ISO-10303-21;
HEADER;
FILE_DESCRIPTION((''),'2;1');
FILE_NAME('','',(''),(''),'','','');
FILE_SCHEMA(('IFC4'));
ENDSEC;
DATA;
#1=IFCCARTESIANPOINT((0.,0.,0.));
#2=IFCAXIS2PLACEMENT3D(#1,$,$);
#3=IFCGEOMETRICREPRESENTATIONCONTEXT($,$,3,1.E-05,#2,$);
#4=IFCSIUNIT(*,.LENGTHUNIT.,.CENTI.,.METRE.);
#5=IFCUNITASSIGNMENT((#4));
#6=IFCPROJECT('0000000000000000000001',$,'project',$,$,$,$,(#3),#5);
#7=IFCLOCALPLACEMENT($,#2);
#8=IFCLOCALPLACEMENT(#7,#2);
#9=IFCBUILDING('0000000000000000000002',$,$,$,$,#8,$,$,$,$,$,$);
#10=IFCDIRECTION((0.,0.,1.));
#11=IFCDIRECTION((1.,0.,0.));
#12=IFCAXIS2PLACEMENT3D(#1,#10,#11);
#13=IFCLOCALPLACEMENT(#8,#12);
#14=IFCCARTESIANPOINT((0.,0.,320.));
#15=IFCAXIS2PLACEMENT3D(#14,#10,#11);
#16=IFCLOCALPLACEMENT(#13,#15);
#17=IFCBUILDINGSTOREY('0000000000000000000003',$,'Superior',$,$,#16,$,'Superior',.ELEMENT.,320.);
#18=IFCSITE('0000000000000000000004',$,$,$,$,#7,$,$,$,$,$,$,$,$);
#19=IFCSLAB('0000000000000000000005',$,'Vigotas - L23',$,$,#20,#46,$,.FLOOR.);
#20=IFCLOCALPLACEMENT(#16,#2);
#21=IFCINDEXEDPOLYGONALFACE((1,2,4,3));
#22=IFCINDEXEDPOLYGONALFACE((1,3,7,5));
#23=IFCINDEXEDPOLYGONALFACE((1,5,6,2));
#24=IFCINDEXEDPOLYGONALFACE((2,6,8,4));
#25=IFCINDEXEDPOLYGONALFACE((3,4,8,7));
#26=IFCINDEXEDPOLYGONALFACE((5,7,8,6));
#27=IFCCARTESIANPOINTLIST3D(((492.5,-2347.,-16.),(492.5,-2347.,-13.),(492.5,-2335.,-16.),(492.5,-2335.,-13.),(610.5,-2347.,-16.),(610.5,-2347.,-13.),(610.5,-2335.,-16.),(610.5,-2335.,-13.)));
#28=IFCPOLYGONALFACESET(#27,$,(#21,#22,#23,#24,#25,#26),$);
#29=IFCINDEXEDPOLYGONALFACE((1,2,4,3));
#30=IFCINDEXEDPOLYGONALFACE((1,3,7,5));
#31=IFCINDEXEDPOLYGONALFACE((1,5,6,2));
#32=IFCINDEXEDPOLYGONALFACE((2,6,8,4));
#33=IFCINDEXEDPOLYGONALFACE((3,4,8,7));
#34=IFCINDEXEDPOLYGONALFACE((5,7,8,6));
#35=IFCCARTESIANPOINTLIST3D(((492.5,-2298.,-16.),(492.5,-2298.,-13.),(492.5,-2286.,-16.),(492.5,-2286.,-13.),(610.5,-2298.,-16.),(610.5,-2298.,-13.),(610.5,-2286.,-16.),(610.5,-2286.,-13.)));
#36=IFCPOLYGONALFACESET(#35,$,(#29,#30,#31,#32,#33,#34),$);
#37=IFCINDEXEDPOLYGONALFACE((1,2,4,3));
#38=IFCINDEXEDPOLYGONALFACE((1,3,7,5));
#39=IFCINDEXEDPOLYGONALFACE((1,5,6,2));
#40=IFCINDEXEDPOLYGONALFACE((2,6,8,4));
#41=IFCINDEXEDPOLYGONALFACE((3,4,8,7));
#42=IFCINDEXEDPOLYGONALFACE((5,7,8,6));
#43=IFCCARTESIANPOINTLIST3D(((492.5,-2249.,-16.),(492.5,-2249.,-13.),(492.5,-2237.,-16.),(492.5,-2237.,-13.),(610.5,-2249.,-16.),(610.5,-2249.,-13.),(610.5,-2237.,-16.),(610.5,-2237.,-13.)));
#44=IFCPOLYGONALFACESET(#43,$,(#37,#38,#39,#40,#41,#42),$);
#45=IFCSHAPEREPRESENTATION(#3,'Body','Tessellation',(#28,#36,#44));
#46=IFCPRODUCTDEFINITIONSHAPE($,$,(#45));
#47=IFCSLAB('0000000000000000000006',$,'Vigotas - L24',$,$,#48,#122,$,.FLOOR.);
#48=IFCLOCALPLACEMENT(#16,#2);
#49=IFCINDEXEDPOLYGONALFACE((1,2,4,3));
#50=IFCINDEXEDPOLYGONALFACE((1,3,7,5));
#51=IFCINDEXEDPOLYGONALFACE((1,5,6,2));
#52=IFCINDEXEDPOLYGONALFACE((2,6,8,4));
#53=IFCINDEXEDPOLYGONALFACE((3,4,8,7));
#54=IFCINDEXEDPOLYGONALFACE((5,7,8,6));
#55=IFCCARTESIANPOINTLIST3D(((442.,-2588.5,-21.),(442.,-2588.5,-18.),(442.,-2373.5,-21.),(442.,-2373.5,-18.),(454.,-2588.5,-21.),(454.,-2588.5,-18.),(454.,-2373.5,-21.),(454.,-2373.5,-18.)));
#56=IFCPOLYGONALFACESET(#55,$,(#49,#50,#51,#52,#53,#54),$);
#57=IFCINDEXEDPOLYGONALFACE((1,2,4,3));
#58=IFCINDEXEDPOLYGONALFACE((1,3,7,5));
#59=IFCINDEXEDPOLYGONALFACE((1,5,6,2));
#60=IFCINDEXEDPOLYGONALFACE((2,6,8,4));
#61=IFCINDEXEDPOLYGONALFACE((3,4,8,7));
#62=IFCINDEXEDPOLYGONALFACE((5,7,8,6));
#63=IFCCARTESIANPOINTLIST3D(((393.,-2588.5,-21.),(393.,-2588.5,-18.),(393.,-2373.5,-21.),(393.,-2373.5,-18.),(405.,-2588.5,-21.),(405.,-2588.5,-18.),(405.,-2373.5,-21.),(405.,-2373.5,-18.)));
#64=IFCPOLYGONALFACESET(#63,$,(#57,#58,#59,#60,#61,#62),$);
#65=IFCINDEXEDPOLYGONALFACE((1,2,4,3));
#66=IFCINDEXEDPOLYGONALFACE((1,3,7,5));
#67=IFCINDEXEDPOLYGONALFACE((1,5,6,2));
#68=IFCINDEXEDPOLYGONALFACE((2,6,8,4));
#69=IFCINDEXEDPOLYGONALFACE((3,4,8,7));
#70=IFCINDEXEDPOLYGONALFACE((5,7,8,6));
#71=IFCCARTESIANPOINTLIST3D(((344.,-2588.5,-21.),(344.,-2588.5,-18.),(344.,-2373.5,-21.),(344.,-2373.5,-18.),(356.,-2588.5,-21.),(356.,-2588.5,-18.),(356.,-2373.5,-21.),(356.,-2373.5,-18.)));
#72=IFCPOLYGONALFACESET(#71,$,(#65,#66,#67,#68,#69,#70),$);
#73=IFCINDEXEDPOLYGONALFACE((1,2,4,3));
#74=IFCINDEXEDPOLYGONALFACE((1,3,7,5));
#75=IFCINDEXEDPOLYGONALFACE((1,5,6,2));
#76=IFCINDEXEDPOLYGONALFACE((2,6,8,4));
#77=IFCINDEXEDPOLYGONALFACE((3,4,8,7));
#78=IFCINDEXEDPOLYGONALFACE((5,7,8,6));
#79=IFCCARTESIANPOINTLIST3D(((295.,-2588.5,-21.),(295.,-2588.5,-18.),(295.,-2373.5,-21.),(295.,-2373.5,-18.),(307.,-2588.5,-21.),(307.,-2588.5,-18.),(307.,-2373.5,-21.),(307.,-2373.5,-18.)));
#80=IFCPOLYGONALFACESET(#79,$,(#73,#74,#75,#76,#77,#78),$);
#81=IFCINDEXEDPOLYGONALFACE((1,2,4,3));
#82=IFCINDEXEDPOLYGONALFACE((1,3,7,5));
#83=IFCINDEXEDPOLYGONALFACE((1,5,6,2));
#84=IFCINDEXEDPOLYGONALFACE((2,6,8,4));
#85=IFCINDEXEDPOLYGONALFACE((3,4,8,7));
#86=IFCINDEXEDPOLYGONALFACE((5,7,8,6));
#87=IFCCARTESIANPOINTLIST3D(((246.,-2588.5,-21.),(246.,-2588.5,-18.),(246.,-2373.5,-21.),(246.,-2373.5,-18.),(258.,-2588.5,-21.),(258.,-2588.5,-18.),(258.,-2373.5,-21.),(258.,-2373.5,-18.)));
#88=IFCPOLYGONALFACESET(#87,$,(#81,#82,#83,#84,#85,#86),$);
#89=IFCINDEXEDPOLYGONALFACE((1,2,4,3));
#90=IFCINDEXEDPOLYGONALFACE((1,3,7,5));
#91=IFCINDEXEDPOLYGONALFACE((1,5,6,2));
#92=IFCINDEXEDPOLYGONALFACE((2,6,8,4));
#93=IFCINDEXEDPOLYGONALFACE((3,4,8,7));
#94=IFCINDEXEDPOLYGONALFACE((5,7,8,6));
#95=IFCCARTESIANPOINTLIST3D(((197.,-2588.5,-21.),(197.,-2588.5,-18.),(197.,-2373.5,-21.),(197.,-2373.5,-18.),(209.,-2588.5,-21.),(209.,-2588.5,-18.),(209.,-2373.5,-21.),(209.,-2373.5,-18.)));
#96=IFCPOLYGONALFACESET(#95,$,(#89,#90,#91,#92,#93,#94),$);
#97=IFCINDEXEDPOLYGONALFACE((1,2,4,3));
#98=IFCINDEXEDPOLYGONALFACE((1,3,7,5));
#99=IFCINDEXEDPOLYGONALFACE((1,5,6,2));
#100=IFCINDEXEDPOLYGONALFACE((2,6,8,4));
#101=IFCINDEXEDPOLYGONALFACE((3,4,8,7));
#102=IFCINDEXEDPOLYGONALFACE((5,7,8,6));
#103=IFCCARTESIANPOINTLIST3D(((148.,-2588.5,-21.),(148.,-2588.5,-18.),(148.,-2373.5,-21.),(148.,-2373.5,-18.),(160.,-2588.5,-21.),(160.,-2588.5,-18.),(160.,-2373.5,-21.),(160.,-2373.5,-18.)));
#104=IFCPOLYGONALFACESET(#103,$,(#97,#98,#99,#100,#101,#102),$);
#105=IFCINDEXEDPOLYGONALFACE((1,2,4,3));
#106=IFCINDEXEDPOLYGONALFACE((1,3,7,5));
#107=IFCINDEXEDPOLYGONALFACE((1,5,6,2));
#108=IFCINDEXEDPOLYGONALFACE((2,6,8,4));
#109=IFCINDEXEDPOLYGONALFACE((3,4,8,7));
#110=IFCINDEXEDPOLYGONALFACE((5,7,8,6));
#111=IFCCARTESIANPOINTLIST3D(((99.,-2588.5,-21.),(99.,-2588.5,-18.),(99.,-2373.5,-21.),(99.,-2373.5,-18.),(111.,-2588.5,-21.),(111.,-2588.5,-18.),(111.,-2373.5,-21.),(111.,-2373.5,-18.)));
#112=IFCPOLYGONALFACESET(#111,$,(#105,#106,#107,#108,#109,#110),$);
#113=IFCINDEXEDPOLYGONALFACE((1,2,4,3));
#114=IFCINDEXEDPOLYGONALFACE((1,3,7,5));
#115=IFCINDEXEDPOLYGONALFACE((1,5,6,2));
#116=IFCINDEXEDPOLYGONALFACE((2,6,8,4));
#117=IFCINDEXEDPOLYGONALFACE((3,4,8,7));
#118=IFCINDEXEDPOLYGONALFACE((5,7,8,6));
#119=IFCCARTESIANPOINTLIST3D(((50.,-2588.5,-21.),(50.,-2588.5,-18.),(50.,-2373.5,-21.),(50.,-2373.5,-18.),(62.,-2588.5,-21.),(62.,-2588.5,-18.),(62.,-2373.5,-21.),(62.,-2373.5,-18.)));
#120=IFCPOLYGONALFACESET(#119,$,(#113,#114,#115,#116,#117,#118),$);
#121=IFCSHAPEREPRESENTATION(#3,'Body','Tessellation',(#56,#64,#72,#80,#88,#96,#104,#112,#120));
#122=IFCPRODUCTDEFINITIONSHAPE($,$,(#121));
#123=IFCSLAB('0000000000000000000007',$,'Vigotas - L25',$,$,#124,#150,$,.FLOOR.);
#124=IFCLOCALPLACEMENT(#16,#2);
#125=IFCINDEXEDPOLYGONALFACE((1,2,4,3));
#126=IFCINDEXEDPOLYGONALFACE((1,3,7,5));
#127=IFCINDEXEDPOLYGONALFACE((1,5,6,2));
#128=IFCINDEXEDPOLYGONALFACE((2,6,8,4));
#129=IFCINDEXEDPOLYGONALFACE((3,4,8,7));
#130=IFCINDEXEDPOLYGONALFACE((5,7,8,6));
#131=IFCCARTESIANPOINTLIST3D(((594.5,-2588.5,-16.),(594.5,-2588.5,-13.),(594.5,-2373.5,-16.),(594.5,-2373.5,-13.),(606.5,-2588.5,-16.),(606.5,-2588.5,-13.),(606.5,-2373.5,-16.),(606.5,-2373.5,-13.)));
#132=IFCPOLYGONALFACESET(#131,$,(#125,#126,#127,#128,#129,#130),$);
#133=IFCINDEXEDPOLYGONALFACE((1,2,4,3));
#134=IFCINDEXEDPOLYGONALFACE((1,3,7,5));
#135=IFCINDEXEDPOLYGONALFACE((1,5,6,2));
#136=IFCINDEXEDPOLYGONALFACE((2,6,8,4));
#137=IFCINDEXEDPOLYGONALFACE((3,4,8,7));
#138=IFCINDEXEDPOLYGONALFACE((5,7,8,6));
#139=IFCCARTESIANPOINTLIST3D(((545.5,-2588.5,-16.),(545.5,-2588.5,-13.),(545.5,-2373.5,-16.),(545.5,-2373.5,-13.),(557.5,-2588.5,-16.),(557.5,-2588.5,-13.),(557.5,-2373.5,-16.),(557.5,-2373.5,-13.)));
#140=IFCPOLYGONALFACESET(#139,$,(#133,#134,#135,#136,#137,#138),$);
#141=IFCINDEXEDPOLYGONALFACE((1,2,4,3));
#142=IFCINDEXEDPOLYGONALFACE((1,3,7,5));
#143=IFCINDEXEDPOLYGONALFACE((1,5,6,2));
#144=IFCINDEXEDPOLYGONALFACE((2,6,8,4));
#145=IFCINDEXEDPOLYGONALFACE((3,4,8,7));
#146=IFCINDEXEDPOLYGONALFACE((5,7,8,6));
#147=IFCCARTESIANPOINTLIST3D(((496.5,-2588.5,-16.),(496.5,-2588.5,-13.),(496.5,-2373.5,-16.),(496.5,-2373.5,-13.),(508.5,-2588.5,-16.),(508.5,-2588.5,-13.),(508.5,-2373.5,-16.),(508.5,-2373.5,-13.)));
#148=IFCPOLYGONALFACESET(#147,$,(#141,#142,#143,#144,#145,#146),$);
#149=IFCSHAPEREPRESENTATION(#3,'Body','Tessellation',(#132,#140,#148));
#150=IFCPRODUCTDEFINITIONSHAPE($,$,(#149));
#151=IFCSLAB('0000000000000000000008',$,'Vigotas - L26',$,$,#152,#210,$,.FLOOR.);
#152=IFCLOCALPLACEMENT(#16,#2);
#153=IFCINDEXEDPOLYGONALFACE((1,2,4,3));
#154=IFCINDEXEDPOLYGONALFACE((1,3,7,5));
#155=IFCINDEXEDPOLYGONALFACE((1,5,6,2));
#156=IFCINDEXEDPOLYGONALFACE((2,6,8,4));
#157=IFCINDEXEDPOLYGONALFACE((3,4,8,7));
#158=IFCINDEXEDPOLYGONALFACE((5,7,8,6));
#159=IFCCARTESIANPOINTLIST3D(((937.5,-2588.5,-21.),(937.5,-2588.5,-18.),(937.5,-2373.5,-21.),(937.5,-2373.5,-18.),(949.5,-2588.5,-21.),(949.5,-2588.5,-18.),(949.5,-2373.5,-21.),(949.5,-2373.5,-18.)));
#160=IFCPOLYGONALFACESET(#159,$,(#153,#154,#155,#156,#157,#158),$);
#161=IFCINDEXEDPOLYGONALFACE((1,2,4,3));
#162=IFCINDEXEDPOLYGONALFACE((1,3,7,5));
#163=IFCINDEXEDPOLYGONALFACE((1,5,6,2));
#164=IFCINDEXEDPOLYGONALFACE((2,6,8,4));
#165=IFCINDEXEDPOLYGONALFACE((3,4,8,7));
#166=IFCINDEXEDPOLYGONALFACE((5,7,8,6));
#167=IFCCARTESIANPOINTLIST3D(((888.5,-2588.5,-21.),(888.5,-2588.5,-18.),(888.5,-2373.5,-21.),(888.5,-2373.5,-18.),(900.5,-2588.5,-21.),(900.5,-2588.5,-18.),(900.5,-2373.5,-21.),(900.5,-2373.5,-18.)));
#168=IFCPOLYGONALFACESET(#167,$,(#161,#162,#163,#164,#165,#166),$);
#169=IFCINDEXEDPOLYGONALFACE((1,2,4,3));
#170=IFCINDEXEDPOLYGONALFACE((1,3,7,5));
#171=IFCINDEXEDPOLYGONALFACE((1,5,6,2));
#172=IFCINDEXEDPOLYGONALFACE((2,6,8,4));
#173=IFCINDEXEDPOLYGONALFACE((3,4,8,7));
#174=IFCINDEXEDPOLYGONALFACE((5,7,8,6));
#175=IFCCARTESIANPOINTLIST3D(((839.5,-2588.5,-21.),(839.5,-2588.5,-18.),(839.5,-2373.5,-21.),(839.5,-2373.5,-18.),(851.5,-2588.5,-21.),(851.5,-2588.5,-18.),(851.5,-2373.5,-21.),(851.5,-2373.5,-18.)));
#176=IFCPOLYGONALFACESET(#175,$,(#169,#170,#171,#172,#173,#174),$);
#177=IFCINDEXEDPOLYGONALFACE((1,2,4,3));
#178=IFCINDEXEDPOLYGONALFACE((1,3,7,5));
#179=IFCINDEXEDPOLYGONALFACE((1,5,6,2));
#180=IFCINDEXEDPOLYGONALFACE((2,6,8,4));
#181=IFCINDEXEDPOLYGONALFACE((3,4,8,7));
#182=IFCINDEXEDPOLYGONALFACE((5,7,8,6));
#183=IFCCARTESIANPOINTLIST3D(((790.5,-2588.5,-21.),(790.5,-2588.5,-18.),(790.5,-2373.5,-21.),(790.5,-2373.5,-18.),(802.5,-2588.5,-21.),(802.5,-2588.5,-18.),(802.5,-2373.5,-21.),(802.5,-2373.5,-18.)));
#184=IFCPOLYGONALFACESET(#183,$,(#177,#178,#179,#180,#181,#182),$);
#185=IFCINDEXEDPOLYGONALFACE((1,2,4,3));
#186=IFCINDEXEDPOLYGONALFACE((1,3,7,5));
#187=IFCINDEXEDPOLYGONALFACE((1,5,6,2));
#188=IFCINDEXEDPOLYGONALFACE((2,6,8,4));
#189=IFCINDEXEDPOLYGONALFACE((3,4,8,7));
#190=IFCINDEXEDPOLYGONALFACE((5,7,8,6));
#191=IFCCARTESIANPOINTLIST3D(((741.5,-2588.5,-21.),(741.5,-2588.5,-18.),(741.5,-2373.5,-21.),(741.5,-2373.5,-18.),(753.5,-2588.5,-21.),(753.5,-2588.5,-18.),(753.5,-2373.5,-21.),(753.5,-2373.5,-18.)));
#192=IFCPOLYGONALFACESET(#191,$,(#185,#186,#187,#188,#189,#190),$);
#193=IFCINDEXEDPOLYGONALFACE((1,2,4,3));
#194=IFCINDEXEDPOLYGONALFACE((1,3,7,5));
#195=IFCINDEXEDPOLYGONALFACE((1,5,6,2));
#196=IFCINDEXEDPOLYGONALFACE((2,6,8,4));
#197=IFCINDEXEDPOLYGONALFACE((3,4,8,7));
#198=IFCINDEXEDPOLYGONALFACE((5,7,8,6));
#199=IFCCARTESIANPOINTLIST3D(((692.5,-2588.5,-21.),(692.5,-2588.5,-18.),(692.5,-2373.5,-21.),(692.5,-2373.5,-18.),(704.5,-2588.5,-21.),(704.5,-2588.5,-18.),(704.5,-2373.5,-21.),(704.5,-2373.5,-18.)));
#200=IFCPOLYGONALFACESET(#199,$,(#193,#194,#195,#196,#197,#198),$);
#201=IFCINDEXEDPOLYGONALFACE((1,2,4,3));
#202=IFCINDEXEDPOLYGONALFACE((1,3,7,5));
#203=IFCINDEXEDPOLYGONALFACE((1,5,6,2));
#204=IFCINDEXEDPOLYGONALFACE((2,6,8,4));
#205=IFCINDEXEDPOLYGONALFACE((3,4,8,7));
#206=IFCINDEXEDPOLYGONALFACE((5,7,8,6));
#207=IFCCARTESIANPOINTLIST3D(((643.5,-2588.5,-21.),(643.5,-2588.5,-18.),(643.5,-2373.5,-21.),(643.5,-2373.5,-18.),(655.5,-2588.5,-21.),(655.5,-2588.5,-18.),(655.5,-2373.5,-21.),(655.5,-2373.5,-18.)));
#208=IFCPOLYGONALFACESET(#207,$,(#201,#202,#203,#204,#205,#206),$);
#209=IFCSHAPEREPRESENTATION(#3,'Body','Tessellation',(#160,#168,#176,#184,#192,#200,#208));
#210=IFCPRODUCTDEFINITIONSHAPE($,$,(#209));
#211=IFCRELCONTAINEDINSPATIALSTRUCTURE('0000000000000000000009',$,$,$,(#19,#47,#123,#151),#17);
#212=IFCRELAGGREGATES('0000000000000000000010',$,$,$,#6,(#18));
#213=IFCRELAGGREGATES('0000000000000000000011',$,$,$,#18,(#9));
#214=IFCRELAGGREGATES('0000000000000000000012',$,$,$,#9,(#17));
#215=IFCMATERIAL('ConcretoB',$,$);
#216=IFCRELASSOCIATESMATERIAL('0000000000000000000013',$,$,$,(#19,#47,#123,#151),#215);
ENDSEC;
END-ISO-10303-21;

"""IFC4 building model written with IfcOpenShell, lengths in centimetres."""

from ifc_helpers import new_model, si_unit, frame, origin, origin_with_axes, place, context, project, spatial, polyline, outline, extrude, material, element, save


model = new_model("IFC4")

# Units and contexts
context_of_model = context(None, 3, precision=1e-05, world=origin())
ifc_project = project(units=[si_unit("LENGTHUNIT", "METRE", prefix="CENTI")], contexts=[context_of_model])

# Site, building, storey
site_placement = place(None, origin())
site = spatial("IfcSite", under=ifc_project, at=site_placement)
building_placement = place(site_placement, origin())
building = spatial("IfcBuilding", under=site, at=building_placement)
placement = place(building_placement, origin_with_axes())
storey_placement = place(placement, frame((0.0, 0.0, 320.0), z_axis=(0.0, 0.0, 1.0), x_axis=(1.0, 0.0, 0.0)))
storey = spatial("IfcBuildingStorey", under=building, at=storey_placement, Name="Superior", LongName="Superior", CompositionType="ELEMENT", Elevation=320.0)

# Shared definitions
ifc_material = material(Name="ConcretoB")

# Slabs
slab_1_placement = place(storey_placement, frame((551.5, -2292.0, -13.0), z_axis=(0.0, 0.0, 1.0), x_axis=(1.0, 0.0, 0.0)))
element("IfcSlab", 1, at=slab_1_placement, inside=storey, material=ifc_material, Name="Vigotas - L23", PredefinedType="FLOOR", context=context_of_model, shape_type="SolidModel", body=[
    extrude(outline(polyline([(6.0, 1.5), (-6.0, 1.5), (-6.0, -1.5), (6.0, -1.5), (6.0, 1.5), (6.0, 1.5)])), frame((-59.0, -49.0, -1.5), z_axis=(1.0, 0.0, 0.0), x_axis=(0.0, -1.0, 0.0)), (0.0, 0.0, 1.0), 118.0),
    extrude(outline(polyline([(6.0, 1.5), (-6.0, 1.5), (-6.0, -1.5), (6.0, -1.5), (6.0, 1.5), (6.0, 1.5)])), frame((-59.0, 0.0, -1.5), z_axis=(1.0, 0.0, 0.0), x_axis=(0.0, -1.0, 0.0)), (0.0, 0.0, 1.0), 118.0),
    extrude(outline(polyline([(6.0, 1.5), (-6.0, 1.5), (-6.0, -1.5), (6.0, -1.5), (6.0, 1.5), (6.0, 1.5)])), frame((-59.0, 49.0, -1.5), z_axis=(1.0, 0.0, 0.0), x_axis=(0.0, -1.0, 0.0)), (0.0, 0.0, 1.0), 118.0),
])
slab_2_placement = place(storey_placement, frame((252.0, -2481.0, -18.0), z_axis=(0.0, 0.0, 1.0), x_axis=(1.0, 0.0, 0.0)))
element("IfcSlab", 2, at=slab_2_placement, inside=storey, material=ifc_material, Name="Vigotas - L24", PredefinedType="FLOOR", context=context_of_model, shape_type="SolidModel", body=[
    extrude(outline(polyline([(6.0, 1.5), (-6.0, 1.5), (-6.0, -1.5), (6.0, -1.5), (6.0, 1.5), (6.0, 1.5)])), frame((196.0, -107.5, -1.5), z_axis=(0.0, 1.0, 0.0), x_axis=(1.0, 0.0, 0.0)), (0.0, 0.0, 1.0), 215.0),
    extrude(outline(polyline([(6.0, 1.5), (-6.0, 1.5), (-6.0, -1.5), (6.0, -1.5), (6.0, 1.5), (6.0, 1.5)])), frame((147.0, -107.5, -1.5), z_axis=(0.0, 1.0, 0.0), x_axis=(1.0, 0.0, 0.0)), (0.0, 0.0, 1.0), 215.0),
    extrude(outline(polyline([(6.0, 1.5), (-6.0, 1.5), (-6.0, -1.5), (6.0, -1.5), (6.0, 1.5), (6.0, 1.5)])), frame((98.0, -107.5, -1.5), z_axis=(0.0, 1.0, 0.0), x_axis=(1.0, 0.0, 0.0)), (0.0, 0.0, 1.0), 215.0),
    extrude(outline(polyline([(6.0, 1.5), (-6.0, 1.5), (-6.0, -1.5), (6.0, -1.5), (6.0, 1.5), (6.0, 1.5)])), frame((49.0, -107.5, -1.5), z_axis=(0.0, 1.0, 0.0), x_axis=(1.0, 0.0, 0.0)), (0.0, 0.0, 1.0), 215.0),
    extrude(outline(polyline([(6.0, 1.5), (-6.0, 1.5), (-6.0, -1.5), (6.0, -1.5), (6.0, 1.5), (6.0, 1.5)])), frame((0.0, -107.5, -1.5), z_axis=(0.0, 1.0, 0.0), x_axis=(1.0, 0.0, 0.0)), (0.0, 0.0, 1.0), 215.0),
    extrude(outline(polyline([(6.0, 1.5), (-6.0, 1.5), (-6.0, -1.5), (6.0, -1.5), (6.0, 1.5), (6.0, 1.5)])), frame((-49.0, -107.5, -1.5), z_axis=(0.0, 1.0, 0.0), x_axis=(1.0, 0.0, 0.0)), (0.0, 0.0, 1.0), 215.0),
    extrude(outline(polyline([(6.0, 1.5), (-6.0, 1.5), (-6.0, -1.5), (6.0, -1.5), (6.0, 1.5), (6.0, 1.5)])), frame((-98.0, -107.5, -1.5), z_axis=(0.0, 1.0, 0.0), x_axis=(1.0, 0.0, 0.0)), (0.0, 0.0, 1.0), 215.0),
    extrude(outline(polyline([(6.0, 1.5), (-6.0, 1.5), (-6.0, -1.5), (6.0, -1.5), (6.0, 1.5), (6.0, 1.5)])), frame((-147.0, -107.5, -1.5), z_axis=(0.0, 1.0, 0.0), x_axis=(1.0, 0.0, 0.0)), (0.0, 0.0, 1.0), 215.0),
    extrude(outline(polyline([(6.0, 1.5), (-6.0, 1.5), (-6.0, -1.5), (6.0, -1.5), (6.0, 1.5), (6.0, 1.5)])), frame((-196.0, -107.5, -1.5), z_axis=(0.0, 1.0, 0.0), x_axis=(1.0, 0.0, 0.0)), (0.0, 0.0, 1.0), 215.0),
])
slab_3_placement = place(storey_placement, frame((551.5, -2481.0, -13.0), z_axis=(0.0, 0.0, 1.0), x_axis=(1.0, 0.0, 0.0)))
element("IfcSlab", 3, at=slab_3_placement, inside=storey, material=ifc_material, Name="Vigotas - L25", PredefinedType="FLOOR", context=context_of_model, shape_type="SolidModel", body=[
    extrude(outline(polyline([(6.0, 1.5), (-6.0, 1.5), (-6.0, -1.5), (6.0, -1.5), (6.0, 1.5), (6.0, 1.5)])), frame((49.0, -107.5, -1.5), z_axis=(0.0, 1.0, 0.0), x_axis=(1.0, 0.0, 0.0)), (0.0, 0.0, 1.0), 215.0),
    extrude(outline(polyline([(6.0, 1.5), (-6.0, 1.5), (-6.0, -1.5), (6.0, -1.5), (6.0, 1.5), (6.0, 1.5)])), frame((0.0, -107.5, -1.5), z_axis=(0.0, 1.0, 0.0), x_axis=(1.0, 0.0, 0.0)), (0.0, 0.0, 1.0), 215.0),
    extrude(outline(polyline([(6.0, 1.5), (-6.0, 1.5), (-6.0, -1.5), (6.0, -1.5), (6.0, 1.5), (6.0, 1.5)])), frame((-49.0, -107.5, -1.5), z_axis=(0.0, 1.0, 0.0), x_axis=(1.0, 0.0, 0.0)), (0.0, 0.0, 1.0), 215.0),
])
slab_4_placement = place(storey_placement, frame((796.5, -2481.0, -18.0), z_axis=(0.0, 0.0, 1.0), x_axis=(1.0, 0.0, 0.0)))
element("IfcSlab", 4, at=slab_4_placement, inside=storey, material=ifc_material, Name="Vigotas - L26", PredefinedType="FLOOR", context=context_of_model, shape_type="SolidModel", body=[
    extrude(outline(polyline([(6.0, 1.5), (-6.0, 1.5), (-6.0, -1.5), (6.0, -1.5), (6.0, 1.5), (6.0, 1.5)])), frame((147.0, -107.5, -1.5), z_axis=(0.0, 1.0, 0.0), x_axis=(1.0, 0.0, 0.0)), (0.0, 0.0, 1.0), 215.0),
    extrude(outline(polyline([(6.0, 1.5), (-6.0, 1.5), (-6.0, -1.5), (6.0, -1.5), (6.0, 1.5), (6.0, 1.5)])), frame((98.0, -107.5, -1.5), z_axis=(0.0, 1.0, 0.0), x_axis=(1.0, 0.0, 0.0)), (0.0, 0.0, 1.0), 215.0),
    extrude(outline(polyline([(6.0, 1.5), (-6.0, 1.5), (-6.0, -1.5), (6.0, -1.5), (6.0, 1.5), (6.0, 1.5)])), frame((49.0, -107.5, -1.5), z_axis=(0.0, 1.0, 0.0), x_axis=(1.0, 0.0, 0.0)), (0.0, 0.0, 1.0), 215.0),
    extrude(outline(polyline([(6.0, 1.5), (-6.0, 1.5), (-6.0, -1.5), (6.0, -1.5), (6.0, 1.5), (6.0, 1.5)])), frame((0.0, -107.5, -1.5), z_axis=(0.0, 1.0, 0.0), x_axis=(1.0, 0.0, 0.0)), (0.0, 0.0, 1.0), 215.0),
    extrude(outline(polyline([(6.0, 1.5), (-6.0, 1.5), (-6.0, -1.5), (6.0, -1.5), (6.0, 1.5), (6.0, 1.5)])), frame((-49.0, -107.5, -1.5), z_axis=(0.0, 1.0, 0.0), x_axis=(1.0, 0.0, 0.0)), (0.0, 0.0, 1.0), 215.0),
    extrude(outline(polyline([(6.0, 1.5), (-6.0, 1.5), (-6.0, -1.5), (6.0, -1.5), (6.0, 1.5), (6.0, 1.5)])), frame((-98.0, -107.5, -1.5), z_axis=(0.0, 1.0, 0.0), x_axis=(1.0, 0.0, 0.0)), (0.0, 0.0, 1.0), 215.0),
    extrude(outline(polyline([(6.0, 1.5), (-6.0, 1.5), (-6.0, -1.5), (6.0, -1.5), (6.0, 1.5), (6.0, 1.5)])), frame((-147.0, -107.5, -1.5), z_axis=(0.0, 1.0, 0.0), x_axis=(1.0, 0.0, 0.0)), (0.0, 0.0, 1.0), 215.0),
])

save(model, "model.ifc")
